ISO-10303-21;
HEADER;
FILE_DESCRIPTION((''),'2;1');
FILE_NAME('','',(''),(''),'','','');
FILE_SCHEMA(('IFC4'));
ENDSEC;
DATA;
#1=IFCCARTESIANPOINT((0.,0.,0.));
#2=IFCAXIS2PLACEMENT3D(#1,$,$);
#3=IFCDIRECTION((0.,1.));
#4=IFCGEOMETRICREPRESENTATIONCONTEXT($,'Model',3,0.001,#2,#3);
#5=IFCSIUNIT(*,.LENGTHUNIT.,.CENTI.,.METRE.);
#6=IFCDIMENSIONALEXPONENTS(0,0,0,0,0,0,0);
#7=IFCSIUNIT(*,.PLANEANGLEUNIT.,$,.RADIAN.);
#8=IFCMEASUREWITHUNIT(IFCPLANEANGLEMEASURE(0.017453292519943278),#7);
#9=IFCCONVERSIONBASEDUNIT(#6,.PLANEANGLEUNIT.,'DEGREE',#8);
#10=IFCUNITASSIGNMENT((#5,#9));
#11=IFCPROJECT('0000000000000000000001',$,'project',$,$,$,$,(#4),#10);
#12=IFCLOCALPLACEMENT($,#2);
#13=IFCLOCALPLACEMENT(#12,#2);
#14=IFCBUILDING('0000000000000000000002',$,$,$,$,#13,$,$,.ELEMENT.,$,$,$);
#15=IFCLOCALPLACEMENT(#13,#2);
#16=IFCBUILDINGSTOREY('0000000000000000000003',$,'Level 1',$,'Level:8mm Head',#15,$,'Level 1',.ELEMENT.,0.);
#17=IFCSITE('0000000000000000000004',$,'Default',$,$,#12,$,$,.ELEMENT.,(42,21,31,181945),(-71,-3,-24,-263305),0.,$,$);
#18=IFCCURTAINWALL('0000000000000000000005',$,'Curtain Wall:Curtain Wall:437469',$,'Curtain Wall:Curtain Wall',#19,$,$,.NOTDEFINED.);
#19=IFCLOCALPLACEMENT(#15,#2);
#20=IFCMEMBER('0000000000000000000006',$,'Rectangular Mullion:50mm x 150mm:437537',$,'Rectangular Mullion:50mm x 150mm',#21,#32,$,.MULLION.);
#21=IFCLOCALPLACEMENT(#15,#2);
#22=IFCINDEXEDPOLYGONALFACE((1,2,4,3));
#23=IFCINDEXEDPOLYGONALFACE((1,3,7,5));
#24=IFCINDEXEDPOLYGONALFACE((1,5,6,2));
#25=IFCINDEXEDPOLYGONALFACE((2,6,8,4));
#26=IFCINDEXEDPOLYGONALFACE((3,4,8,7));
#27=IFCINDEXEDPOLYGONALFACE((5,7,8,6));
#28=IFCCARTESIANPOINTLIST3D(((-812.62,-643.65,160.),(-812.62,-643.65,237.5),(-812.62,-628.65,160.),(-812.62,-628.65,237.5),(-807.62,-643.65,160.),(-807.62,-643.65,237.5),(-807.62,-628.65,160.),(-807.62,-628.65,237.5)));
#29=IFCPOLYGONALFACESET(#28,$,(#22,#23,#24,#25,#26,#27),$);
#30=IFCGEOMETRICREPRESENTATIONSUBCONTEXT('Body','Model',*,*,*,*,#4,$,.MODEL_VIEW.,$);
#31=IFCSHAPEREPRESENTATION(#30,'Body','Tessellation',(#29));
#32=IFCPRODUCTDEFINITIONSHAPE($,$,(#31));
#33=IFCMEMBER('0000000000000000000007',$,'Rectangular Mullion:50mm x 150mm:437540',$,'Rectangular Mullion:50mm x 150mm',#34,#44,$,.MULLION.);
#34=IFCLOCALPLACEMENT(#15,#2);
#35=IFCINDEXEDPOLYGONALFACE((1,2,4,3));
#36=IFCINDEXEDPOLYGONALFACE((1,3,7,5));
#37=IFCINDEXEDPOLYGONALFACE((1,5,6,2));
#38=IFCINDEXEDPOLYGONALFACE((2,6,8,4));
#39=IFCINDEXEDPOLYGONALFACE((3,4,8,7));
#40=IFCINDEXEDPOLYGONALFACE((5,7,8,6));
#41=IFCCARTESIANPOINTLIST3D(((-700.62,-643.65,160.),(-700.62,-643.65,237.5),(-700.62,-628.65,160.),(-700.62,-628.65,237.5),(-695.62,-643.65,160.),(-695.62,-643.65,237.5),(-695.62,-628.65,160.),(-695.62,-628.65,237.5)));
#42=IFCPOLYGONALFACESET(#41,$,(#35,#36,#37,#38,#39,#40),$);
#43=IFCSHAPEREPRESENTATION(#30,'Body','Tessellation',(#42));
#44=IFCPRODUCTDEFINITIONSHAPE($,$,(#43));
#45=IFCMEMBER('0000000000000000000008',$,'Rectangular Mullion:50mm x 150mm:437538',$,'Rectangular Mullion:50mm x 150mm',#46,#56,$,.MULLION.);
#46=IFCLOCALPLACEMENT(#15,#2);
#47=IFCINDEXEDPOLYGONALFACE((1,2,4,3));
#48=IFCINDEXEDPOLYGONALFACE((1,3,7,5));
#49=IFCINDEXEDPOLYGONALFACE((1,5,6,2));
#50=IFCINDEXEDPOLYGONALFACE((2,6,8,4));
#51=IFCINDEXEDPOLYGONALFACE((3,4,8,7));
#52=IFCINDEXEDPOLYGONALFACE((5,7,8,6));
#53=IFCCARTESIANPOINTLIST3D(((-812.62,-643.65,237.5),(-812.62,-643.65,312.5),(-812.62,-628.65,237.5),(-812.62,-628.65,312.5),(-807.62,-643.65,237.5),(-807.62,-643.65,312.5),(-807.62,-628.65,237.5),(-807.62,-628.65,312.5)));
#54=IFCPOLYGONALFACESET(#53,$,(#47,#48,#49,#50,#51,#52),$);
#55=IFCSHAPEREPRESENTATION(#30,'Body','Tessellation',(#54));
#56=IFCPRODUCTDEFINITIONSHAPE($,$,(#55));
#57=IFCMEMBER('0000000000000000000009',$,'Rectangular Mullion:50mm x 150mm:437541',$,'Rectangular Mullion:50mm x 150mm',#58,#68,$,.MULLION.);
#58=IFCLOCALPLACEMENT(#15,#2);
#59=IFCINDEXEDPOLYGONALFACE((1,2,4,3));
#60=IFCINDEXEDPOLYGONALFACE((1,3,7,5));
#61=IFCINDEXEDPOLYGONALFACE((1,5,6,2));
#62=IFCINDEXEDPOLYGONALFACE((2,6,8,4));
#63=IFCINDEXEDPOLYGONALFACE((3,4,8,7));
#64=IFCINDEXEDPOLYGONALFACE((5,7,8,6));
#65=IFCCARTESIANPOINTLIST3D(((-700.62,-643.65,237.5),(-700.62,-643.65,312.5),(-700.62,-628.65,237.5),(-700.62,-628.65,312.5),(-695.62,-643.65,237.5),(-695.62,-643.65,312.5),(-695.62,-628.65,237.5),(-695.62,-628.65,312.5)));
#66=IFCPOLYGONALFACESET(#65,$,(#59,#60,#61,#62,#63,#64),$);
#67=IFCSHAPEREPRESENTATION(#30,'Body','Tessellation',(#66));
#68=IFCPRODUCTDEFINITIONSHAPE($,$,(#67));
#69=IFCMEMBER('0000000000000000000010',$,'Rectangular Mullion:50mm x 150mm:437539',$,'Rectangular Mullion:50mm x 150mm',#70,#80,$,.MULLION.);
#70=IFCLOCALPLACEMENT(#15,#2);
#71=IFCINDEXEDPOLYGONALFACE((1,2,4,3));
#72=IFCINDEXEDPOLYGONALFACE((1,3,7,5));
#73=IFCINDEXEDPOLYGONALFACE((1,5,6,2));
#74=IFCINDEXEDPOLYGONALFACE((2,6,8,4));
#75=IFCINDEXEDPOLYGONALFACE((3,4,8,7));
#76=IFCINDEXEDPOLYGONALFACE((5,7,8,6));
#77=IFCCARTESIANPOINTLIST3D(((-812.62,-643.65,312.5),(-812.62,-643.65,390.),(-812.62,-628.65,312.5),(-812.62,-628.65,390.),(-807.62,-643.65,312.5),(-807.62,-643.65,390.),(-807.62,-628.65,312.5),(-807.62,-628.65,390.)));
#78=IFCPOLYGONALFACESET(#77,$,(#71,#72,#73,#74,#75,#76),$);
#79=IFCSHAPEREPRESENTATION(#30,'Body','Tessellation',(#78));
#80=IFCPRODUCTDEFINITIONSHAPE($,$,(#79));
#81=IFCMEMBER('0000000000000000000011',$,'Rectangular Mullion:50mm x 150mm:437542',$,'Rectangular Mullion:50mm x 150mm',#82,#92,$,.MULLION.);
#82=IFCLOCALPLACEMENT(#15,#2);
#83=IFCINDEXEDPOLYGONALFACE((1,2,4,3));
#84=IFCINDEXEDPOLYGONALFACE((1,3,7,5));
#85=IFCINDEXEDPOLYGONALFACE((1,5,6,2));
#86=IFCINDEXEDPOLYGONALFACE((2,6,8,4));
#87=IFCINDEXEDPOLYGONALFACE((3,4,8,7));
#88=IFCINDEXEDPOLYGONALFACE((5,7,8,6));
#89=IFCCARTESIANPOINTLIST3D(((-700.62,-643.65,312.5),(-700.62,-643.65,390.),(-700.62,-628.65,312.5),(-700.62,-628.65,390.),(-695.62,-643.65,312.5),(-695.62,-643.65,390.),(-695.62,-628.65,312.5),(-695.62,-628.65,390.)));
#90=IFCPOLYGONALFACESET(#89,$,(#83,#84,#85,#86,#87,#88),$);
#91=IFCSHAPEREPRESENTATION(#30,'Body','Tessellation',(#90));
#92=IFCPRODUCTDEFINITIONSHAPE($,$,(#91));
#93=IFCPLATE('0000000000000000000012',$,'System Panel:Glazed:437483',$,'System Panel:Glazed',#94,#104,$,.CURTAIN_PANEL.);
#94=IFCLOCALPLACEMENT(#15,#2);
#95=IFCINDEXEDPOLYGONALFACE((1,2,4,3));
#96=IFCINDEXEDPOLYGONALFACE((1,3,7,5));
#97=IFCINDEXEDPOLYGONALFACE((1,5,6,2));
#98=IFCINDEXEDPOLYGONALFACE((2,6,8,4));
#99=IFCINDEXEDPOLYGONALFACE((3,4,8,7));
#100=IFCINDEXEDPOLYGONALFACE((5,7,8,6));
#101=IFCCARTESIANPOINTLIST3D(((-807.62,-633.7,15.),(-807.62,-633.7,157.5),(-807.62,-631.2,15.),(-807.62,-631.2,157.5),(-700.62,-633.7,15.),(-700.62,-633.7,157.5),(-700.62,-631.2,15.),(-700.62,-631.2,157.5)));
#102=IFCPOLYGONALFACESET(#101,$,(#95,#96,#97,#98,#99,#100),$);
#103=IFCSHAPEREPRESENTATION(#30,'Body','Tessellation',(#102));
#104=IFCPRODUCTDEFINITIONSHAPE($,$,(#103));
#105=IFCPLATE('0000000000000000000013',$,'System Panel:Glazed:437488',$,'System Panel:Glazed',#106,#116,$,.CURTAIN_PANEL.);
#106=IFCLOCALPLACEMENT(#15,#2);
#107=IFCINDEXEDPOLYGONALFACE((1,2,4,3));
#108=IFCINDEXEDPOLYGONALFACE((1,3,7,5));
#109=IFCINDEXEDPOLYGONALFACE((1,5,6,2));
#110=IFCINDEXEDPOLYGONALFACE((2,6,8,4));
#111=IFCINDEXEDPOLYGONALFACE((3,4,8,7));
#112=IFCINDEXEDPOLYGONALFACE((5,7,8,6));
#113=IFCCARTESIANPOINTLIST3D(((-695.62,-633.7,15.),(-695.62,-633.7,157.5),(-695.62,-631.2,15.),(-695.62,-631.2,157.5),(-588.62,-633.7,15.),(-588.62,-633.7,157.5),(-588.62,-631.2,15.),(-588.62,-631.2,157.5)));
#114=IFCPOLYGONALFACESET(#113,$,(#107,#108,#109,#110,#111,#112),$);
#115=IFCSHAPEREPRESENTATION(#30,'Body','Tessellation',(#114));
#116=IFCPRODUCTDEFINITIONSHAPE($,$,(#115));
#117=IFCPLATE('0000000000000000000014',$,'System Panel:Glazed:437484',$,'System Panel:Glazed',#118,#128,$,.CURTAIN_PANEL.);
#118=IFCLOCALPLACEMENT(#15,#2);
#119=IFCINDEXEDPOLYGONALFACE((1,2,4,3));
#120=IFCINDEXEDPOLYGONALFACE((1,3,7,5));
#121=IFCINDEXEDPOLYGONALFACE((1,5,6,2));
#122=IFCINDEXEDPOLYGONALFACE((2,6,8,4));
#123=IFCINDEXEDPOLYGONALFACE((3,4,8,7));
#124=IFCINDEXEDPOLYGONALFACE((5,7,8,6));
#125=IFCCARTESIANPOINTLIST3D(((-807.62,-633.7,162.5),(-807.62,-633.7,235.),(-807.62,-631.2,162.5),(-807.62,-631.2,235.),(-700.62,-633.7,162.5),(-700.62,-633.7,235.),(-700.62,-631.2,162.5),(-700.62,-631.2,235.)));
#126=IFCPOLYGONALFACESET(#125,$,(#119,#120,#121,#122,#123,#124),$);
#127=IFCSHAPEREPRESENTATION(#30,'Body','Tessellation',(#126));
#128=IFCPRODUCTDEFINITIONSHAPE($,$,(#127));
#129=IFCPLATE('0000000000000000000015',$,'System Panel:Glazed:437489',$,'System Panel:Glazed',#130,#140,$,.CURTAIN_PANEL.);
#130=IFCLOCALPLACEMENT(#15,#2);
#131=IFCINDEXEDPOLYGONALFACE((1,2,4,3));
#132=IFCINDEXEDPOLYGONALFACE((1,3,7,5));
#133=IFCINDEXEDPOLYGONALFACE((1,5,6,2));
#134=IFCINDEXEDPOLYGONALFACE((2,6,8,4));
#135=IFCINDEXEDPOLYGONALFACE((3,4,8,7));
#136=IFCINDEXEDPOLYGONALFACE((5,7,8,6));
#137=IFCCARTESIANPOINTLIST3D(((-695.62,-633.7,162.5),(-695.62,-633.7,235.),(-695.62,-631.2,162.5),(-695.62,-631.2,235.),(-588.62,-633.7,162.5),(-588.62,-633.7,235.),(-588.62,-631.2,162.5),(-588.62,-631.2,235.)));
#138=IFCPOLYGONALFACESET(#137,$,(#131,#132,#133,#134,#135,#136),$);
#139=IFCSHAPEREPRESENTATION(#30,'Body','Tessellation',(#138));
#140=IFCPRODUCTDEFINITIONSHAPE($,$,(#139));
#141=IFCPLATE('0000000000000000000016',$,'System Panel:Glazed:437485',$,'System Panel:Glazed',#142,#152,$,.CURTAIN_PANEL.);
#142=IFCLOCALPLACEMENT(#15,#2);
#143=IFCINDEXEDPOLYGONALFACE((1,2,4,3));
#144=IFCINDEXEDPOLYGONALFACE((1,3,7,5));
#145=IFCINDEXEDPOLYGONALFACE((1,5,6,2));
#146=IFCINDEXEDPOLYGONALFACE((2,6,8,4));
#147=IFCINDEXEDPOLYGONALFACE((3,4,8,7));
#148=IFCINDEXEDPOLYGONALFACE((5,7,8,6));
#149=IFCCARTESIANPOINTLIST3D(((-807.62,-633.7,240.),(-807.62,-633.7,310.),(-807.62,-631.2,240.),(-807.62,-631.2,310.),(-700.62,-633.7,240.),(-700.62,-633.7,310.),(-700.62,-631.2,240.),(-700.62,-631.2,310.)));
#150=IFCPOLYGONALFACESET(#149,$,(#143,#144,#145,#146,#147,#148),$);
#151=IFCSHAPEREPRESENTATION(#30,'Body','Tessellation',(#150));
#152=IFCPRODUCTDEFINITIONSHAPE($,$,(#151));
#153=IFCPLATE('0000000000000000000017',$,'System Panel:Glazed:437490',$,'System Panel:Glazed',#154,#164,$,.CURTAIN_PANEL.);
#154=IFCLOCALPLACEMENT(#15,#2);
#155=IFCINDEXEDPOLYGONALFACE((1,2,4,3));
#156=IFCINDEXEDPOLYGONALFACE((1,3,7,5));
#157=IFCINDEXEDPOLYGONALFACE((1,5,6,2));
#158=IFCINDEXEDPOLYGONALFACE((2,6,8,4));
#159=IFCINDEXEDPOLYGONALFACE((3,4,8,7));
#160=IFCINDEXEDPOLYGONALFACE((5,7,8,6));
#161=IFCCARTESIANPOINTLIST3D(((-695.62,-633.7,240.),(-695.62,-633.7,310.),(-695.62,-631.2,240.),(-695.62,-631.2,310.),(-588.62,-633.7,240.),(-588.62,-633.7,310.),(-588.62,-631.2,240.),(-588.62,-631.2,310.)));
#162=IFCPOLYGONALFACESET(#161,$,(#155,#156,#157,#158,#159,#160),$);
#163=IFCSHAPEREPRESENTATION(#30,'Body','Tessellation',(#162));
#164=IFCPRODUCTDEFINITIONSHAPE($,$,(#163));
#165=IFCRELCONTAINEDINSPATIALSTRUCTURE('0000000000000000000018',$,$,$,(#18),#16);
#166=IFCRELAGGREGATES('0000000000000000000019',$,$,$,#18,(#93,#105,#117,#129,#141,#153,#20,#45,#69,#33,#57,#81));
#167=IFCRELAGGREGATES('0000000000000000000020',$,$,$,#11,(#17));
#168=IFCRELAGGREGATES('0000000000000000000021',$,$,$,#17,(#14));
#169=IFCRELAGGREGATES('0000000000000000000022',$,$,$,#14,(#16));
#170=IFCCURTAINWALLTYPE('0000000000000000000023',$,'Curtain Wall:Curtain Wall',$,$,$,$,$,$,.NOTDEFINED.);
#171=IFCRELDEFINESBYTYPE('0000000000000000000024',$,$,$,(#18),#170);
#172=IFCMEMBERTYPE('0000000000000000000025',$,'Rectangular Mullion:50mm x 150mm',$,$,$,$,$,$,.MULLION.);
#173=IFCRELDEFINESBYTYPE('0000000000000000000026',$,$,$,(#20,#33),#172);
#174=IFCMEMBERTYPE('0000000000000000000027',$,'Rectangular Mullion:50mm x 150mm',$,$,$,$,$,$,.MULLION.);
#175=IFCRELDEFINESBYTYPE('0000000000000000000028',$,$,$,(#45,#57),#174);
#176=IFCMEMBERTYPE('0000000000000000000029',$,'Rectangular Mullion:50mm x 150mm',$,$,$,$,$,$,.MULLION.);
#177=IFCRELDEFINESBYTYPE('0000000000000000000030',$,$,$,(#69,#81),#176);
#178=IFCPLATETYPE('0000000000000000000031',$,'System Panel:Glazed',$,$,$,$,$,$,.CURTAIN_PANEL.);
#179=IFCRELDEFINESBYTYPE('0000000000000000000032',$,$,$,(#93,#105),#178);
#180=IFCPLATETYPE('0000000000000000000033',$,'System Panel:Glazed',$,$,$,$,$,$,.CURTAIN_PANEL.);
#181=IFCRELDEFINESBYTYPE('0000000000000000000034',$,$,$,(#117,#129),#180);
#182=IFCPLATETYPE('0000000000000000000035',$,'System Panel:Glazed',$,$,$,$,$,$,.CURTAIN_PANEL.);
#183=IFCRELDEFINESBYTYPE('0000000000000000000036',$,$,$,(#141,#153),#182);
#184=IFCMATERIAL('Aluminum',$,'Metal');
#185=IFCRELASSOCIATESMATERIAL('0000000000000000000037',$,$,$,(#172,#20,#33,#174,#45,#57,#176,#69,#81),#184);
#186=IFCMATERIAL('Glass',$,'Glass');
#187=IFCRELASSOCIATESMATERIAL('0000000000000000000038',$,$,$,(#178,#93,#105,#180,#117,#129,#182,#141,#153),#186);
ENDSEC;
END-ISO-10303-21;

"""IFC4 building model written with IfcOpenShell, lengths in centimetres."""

from ifc_helpers import new_model, entity, si_unit, converted_unit, direction, frame, origin, place, context, subcontext, project, spatial, indexed_curve, outline, extrude, source, transform, mapped, material, type_object, type_shapes, element, aggregate, save


model = new_model("IFC4")

# Units and contexts
model_context = context("Model", 3, precision=0.001, world=origin(), true_north=direction((0.0, 1.0)))
body_context = subcontext(model_context, "Body", "Model", "MODEL_VIEW")
ifc_project = project(units=[si_unit("LENGTHUNIT", "METRE", prefix="CENTI"), converted_unit("PLANEANGLEUNIT", "DEGREE", entity("IfcPlaneAngleMeasure", 0.017453292519943278), si_unit("PLANEANGLEUNIT", "RADIAN"), dimensions=[0, 0, 0, 0, 0, 0, 0])], contexts=[model_context])

# Site, building, storey
site_placement = place(None, origin())
site = spatial("IfcSite", under=ifc_project, at=site_placement, Name="Default", CompositionType="ELEMENT", RefLatitude=(42, 21, 31, 181945), RefLongitude=(-71, -3, -24, -263305), RefElevation=0.0)
building_placement = place(site_placement, origin())
building = spatial("IfcBuilding", under=site, at=building_placement, CompositionType="ELEMENT")
storey_placement = place(building_placement, origin())
storey = spatial("IfcBuildingStorey", under=building, at=storey_placement, Name="Level 1", ObjectType="Level:8mm Head", LongName="Level 1", CompositionType="ELEMENT", Elevation=0.0)

# Curtain wall, members, plates
curtain_wall_type = type_object("IfcCurtainWallType", Name="Curtain Wall:Curtain Wall", PredefinedType="NOTDEFINED")
curtain_wall_placement = place(storey_placement, origin())
curtain_wall = element("IfcCurtainWall", 1, at=curtain_wall_placement, inside=storey, type_object=curtain_wall_type, Name="Curtain Wall:Curtain Wall:437469", ObjectType="Curtain Wall:Curtain Wall", PredefinedType="NOTDEFINED")
ifc_material_1 = material(Name="Aluminum", Category="Metal")
member_type_1 = type_object("IfcMemberType", Name="Rectangular Mullion:50mm x 150mm", PredefinedType="MULLION", material=ifc_material_1)
shared_shape_1 = source(origin(), body_context, "Body", "SweptSolid", [
    extrude(outline(indexed_curve([(-2.5, -7.5), (2.5, -7.5), (2.5, 7.5), (-2.5, 7.5), (-2.5, -7.5)], self_intersect=False)), frame((0.0, 0.0, -77.5), z_axis=(0.0, 0.0, 1.0), x_axis=(-1.0, 0.0, 0.0)), (0.0, 0.0, 1.0), 77.5),
])
type_shapes(member_type_1, [shared_shape_1])
member_1_placement = place(curtain_wall_placement, frame((-810.12, -636.15, 160.0), z_axis=(0.0, 0.0, -1.0), x_axis=(1.0, 0.0, 0.0)))
member_1 = element("IfcMember", 2, at=member_1_placement, type_object=member_type_1, material=ifc_material_1, Name="Rectangular Mullion:50mm x 150mm:437537", ObjectType="Rectangular Mullion:50mm x 150mm", PredefinedType="MULLION", context=body_context, shape_type="MappedRepresentation", body=[
    mapped(shared_shape_1, transform((0.0, 0.0, 0.0), scale=1.0)),
])
member_2_placement = place(curtain_wall_placement, frame((-698.12, -636.15, 160.0), z_axis=(0.0, 0.0, -1.0), x_axis=(1.0, 0.0, 0.0)))
member_2 = element("IfcMember", 3, at=member_2_placement, type_object=member_type_1, material=ifc_material_1, Name="Rectangular Mullion:50mm x 150mm:437540", ObjectType="Rectangular Mullion:50mm x 150mm", PredefinedType="MULLION", context=body_context, shape_type="MappedRepresentation", body=[
    mapped(shared_shape_1, transform((0.0, 0.0, 0.0), scale=1.0)),
])
member_type_2 = type_object("IfcMemberType", Name="Rectangular Mullion:50mm x 150mm", PredefinedType="MULLION", material=ifc_material_1)
shared_shape_2 = source(origin(), body_context, "Body", "SweptSolid", [
    extrude(outline(indexed_curve([(-2.5, -7.5), (2.5, -7.5), (2.5, 7.5), (-2.5, 7.5), (-2.5, -7.5)], self_intersect=False)), frame((0.0, 0.0, -75.0), z_axis=(0.0, 0.0, 1.0), x_axis=(-1.0, 0.0, 0.0)), (0.0, 0.0, 1.0), 75.0),
])
type_shapes(member_type_2, [shared_shape_2])
member_3_placement = place(curtain_wall_placement, frame((-810.12, -636.15, 237.5), z_axis=(0.0, 0.0, -1.0), x_axis=(1.0, 0.0, 0.0)))
member_3 = element("IfcMember", 4, at=member_3_placement, type_object=member_type_2, material=ifc_material_1, Name="Rectangular Mullion:50mm x 150mm:437538", ObjectType="Rectangular Mullion:50mm x 150mm", PredefinedType="MULLION", context=body_context, shape_type="MappedRepresentation", body=[
    mapped(shared_shape_2, transform((0.0, 0.0, 0.0), scale=1.0)),
])
member_4_placement = place(curtain_wall_placement, frame((-698.12, -636.15, 237.5), z_axis=(0.0, 0.0, -1.0), x_axis=(1.0, 0.0, 0.0)))
member_4 = element("IfcMember", 5, at=member_4_placement, type_object=member_type_2, material=ifc_material_1, Name="Rectangular Mullion:50mm x 150mm:437541", ObjectType="Rectangular Mullion:50mm x 150mm", PredefinedType="MULLION", context=body_context, shape_type="MappedRepresentation", body=[
    mapped(shared_shape_2, transform((0.0, 0.0, 0.0), scale=1.0)),
])
member_type_3 = type_object("IfcMemberType", Name="Rectangular Mullion:50mm x 150mm", PredefinedType="MULLION", material=ifc_material_1)
shared_shape_3 = source(origin(), body_context, "Body", "SweptSolid", [
    extrude(outline(indexed_curve([(-2.5, -7.5), (2.5, -7.5), (2.5, 7.5), (-2.5, 7.5), (-2.5, -7.5)], self_intersect=False)), frame((0.0, 0.0, -77.5), z_axis=(0.0, 0.0, 1.0), x_axis=(-1.0, 0.0, 0.0)), (0.0, 0.0, 1.0), 77.5),
])
type_shapes(member_type_3, [shared_shape_3])
member_5_placement = place(curtain_wall_placement, frame((-810.12, -636.15, 312.5), z_axis=(0.0, 0.0, -1.0), x_axis=(1.0, 0.0, 0.0)))
member_5 = element("IfcMember", 6, at=member_5_placement, type_object=member_type_3, material=ifc_material_1, Name="Rectangular Mullion:50mm x 150mm:437539", ObjectType="Rectangular Mullion:50mm x 150mm", PredefinedType="MULLION", context=body_context, shape_type="MappedRepresentation", body=[
    mapped(shared_shape_3, transform((0.0, 0.0, 0.0), scale=1.0)),
])
member_6_placement = place(curtain_wall_placement, frame((-698.12, -636.15, 312.5), z_axis=(0.0, 0.0, -1.0), x_axis=(1.0, 0.0, 0.0)))
member_6 = element("IfcMember", 7, at=member_6_placement, type_object=member_type_3, material=ifc_material_1, Name="Rectangular Mullion:50mm x 150mm:437542", ObjectType="Rectangular Mullion:50mm x 150mm", PredefinedType="MULLION", context=body_context, shape_type="MappedRepresentation", body=[
    mapped(shared_shape_3, transform((0.0, 0.0, 0.0), scale=1.0)),
])
ifc_material_2 = material(Name="Glass", Category="Glass")
plate_type_1 = type_object("IfcPlateType", Name="System Panel:Glazed", PredefinedType="CURTAIN_PANEL", material=ifc_material_2)
shared_shape_4 = source(origin(), body_context, "Body", "SweptSolid", [
    extrude(outline(indexed_curve([(-1.25, -53.5), (1.25, -53.5), (1.25, 53.5), (-1.25, 53.5), (-1.25, -53.5)], self_intersect=False)), frame((0.0, 3.7, 0.0), z_axis=(0.0, 0.0, 1.0), x_axis=(0.0, 1.0, 0.0)), (0.0, 0.0, 1.0), 142.5),
])
type_shapes(plate_type_1, [shared_shape_4])
plate_1_placement = place(curtain_wall_placement, frame((-754.12, -636.15, 15.0)))
plate_1 = element("IfcPlate", 8, at=plate_1_placement, type_object=plate_type_1, material=ifc_material_2, Name="System Panel:Glazed:437483", ObjectType="System Panel:Glazed", PredefinedType="CURTAIN_PANEL", context=body_context, shape_type="MappedRepresentation", body=[
    mapped(shared_shape_4, transform((0.0, 0.0, 0.0), scale=1.0)),
])
plate_2_placement = place(curtain_wall_placement, frame((-642.12, -636.15, 15.0)))
plate_2 = element("IfcPlate", 9, at=plate_2_placement, type_object=plate_type_1, material=ifc_material_2, Name="System Panel:Glazed:437488", ObjectType="System Panel:Glazed", PredefinedType="CURTAIN_PANEL", context=body_context, shape_type="MappedRepresentation", body=[
    mapped(shared_shape_4, transform((0.0, 0.0, 0.0), scale=1.0)),
])
plate_type_2 = type_object("IfcPlateType", Name="System Panel:Glazed", PredefinedType="CURTAIN_PANEL", material=ifc_material_2)
shared_shape_5 = source(origin(), body_context, "Body", "SweptSolid", [
    extrude(outline(indexed_curve([(-1.25, -53.5), (1.25, -53.5), (1.25, 53.5), (-1.25, 53.5), (-1.25, -53.5)], self_intersect=False)), frame((0.0, 3.7, 0.0), z_axis=(0.0, 0.0, 1.0), x_axis=(0.0, 1.0, 0.0)), (0.0, 0.0, 1.0), 72.5),
])
type_shapes(plate_type_2, [shared_shape_5])
plate_3_placement = place(curtain_wall_placement, frame((-754.12, -636.15, 162.5)))
plate_3 = element("IfcPlate", 10, at=plate_3_placement, type_object=plate_type_2, material=ifc_material_2, Name="System Panel:Glazed:437484", ObjectType="System Panel:Glazed", PredefinedType="CURTAIN_PANEL", context=body_context, shape_type="MappedRepresentation", body=[
    mapped(shared_shape_5, transform((0.0, 0.0, 0.0), scale=1.0)),
])
plate_4_placement = place(curtain_wall_placement, frame((-642.12, -636.15, 162.5)))
plate_4 = element("IfcPlate", 11, at=plate_4_placement, type_object=plate_type_2, material=ifc_material_2, Name="System Panel:Glazed:437489", ObjectType="System Panel:Glazed", PredefinedType="CURTAIN_PANEL", context=body_context, shape_type="MappedRepresentation", body=[
    mapped(shared_shape_5, transform((0.0, 0.0, 0.0), scale=1.0)),
])
plate_type_3 = type_object("IfcPlateType", Name="System Panel:Glazed", PredefinedType="CURTAIN_PANEL", material=ifc_material_2)
shared_shape_6 = source(origin(), body_context, "Body", "SweptSolid", [
    extrude(outline(indexed_curve([(-1.25, -53.5), (1.25, -53.5), (1.25, 53.5), (-1.25, 53.5), (-1.25, -53.5)], self_intersect=False)), frame((0.0, 3.7, 0.0), z_axis=(0.0, 0.0, 1.0), x_axis=(0.0, 1.0, 0.0)), (0.0, 0.0, 1.0), 70.0),
])
type_shapes(plate_type_3, [shared_shape_6])
plate_5_placement = place(curtain_wall_placement, frame((-754.12, -636.15, 240.0)))
plate_5 = element("IfcPlate", 12, at=plate_5_placement, type_object=plate_type_3, material=ifc_material_2, Name="System Panel:Glazed:437485", ObjectType="System Panel:Glazed", PredefinedType="CURTAIN_PANEL", context=body_context, shape_type="MappedRepresentation", body=[
    mapped(shared_shape_6, transform((0.0, 0.0, 0.0), scale=1.0)),
])
plate_6_placement = place(curtain_wall_placement, frame((-642.12, -636.15, 240.0)))
plate_6 = element("IfcPlate", 13, at=plate_6_placement, type_object=plate_type_3, material=ifc_material_2, Name="System Panel:Glazed:437490", ObjectType="System Panel:Glazed", PredefinedType="CURTAIN_PANEL", context=body_context, shape_type="MappedRepresentation", body=[
    mapped(shared_shape_6, transform((0.0, 0.0, 0.0), scale=1.0)),
])
aggregate(curtain_wall, [plate_1, plate_2, plate_3, plate_4, plate_5, plate_6, member_1, member_3, member_5, member_2, member_4, member_6])

save(model, "model.ifc")
